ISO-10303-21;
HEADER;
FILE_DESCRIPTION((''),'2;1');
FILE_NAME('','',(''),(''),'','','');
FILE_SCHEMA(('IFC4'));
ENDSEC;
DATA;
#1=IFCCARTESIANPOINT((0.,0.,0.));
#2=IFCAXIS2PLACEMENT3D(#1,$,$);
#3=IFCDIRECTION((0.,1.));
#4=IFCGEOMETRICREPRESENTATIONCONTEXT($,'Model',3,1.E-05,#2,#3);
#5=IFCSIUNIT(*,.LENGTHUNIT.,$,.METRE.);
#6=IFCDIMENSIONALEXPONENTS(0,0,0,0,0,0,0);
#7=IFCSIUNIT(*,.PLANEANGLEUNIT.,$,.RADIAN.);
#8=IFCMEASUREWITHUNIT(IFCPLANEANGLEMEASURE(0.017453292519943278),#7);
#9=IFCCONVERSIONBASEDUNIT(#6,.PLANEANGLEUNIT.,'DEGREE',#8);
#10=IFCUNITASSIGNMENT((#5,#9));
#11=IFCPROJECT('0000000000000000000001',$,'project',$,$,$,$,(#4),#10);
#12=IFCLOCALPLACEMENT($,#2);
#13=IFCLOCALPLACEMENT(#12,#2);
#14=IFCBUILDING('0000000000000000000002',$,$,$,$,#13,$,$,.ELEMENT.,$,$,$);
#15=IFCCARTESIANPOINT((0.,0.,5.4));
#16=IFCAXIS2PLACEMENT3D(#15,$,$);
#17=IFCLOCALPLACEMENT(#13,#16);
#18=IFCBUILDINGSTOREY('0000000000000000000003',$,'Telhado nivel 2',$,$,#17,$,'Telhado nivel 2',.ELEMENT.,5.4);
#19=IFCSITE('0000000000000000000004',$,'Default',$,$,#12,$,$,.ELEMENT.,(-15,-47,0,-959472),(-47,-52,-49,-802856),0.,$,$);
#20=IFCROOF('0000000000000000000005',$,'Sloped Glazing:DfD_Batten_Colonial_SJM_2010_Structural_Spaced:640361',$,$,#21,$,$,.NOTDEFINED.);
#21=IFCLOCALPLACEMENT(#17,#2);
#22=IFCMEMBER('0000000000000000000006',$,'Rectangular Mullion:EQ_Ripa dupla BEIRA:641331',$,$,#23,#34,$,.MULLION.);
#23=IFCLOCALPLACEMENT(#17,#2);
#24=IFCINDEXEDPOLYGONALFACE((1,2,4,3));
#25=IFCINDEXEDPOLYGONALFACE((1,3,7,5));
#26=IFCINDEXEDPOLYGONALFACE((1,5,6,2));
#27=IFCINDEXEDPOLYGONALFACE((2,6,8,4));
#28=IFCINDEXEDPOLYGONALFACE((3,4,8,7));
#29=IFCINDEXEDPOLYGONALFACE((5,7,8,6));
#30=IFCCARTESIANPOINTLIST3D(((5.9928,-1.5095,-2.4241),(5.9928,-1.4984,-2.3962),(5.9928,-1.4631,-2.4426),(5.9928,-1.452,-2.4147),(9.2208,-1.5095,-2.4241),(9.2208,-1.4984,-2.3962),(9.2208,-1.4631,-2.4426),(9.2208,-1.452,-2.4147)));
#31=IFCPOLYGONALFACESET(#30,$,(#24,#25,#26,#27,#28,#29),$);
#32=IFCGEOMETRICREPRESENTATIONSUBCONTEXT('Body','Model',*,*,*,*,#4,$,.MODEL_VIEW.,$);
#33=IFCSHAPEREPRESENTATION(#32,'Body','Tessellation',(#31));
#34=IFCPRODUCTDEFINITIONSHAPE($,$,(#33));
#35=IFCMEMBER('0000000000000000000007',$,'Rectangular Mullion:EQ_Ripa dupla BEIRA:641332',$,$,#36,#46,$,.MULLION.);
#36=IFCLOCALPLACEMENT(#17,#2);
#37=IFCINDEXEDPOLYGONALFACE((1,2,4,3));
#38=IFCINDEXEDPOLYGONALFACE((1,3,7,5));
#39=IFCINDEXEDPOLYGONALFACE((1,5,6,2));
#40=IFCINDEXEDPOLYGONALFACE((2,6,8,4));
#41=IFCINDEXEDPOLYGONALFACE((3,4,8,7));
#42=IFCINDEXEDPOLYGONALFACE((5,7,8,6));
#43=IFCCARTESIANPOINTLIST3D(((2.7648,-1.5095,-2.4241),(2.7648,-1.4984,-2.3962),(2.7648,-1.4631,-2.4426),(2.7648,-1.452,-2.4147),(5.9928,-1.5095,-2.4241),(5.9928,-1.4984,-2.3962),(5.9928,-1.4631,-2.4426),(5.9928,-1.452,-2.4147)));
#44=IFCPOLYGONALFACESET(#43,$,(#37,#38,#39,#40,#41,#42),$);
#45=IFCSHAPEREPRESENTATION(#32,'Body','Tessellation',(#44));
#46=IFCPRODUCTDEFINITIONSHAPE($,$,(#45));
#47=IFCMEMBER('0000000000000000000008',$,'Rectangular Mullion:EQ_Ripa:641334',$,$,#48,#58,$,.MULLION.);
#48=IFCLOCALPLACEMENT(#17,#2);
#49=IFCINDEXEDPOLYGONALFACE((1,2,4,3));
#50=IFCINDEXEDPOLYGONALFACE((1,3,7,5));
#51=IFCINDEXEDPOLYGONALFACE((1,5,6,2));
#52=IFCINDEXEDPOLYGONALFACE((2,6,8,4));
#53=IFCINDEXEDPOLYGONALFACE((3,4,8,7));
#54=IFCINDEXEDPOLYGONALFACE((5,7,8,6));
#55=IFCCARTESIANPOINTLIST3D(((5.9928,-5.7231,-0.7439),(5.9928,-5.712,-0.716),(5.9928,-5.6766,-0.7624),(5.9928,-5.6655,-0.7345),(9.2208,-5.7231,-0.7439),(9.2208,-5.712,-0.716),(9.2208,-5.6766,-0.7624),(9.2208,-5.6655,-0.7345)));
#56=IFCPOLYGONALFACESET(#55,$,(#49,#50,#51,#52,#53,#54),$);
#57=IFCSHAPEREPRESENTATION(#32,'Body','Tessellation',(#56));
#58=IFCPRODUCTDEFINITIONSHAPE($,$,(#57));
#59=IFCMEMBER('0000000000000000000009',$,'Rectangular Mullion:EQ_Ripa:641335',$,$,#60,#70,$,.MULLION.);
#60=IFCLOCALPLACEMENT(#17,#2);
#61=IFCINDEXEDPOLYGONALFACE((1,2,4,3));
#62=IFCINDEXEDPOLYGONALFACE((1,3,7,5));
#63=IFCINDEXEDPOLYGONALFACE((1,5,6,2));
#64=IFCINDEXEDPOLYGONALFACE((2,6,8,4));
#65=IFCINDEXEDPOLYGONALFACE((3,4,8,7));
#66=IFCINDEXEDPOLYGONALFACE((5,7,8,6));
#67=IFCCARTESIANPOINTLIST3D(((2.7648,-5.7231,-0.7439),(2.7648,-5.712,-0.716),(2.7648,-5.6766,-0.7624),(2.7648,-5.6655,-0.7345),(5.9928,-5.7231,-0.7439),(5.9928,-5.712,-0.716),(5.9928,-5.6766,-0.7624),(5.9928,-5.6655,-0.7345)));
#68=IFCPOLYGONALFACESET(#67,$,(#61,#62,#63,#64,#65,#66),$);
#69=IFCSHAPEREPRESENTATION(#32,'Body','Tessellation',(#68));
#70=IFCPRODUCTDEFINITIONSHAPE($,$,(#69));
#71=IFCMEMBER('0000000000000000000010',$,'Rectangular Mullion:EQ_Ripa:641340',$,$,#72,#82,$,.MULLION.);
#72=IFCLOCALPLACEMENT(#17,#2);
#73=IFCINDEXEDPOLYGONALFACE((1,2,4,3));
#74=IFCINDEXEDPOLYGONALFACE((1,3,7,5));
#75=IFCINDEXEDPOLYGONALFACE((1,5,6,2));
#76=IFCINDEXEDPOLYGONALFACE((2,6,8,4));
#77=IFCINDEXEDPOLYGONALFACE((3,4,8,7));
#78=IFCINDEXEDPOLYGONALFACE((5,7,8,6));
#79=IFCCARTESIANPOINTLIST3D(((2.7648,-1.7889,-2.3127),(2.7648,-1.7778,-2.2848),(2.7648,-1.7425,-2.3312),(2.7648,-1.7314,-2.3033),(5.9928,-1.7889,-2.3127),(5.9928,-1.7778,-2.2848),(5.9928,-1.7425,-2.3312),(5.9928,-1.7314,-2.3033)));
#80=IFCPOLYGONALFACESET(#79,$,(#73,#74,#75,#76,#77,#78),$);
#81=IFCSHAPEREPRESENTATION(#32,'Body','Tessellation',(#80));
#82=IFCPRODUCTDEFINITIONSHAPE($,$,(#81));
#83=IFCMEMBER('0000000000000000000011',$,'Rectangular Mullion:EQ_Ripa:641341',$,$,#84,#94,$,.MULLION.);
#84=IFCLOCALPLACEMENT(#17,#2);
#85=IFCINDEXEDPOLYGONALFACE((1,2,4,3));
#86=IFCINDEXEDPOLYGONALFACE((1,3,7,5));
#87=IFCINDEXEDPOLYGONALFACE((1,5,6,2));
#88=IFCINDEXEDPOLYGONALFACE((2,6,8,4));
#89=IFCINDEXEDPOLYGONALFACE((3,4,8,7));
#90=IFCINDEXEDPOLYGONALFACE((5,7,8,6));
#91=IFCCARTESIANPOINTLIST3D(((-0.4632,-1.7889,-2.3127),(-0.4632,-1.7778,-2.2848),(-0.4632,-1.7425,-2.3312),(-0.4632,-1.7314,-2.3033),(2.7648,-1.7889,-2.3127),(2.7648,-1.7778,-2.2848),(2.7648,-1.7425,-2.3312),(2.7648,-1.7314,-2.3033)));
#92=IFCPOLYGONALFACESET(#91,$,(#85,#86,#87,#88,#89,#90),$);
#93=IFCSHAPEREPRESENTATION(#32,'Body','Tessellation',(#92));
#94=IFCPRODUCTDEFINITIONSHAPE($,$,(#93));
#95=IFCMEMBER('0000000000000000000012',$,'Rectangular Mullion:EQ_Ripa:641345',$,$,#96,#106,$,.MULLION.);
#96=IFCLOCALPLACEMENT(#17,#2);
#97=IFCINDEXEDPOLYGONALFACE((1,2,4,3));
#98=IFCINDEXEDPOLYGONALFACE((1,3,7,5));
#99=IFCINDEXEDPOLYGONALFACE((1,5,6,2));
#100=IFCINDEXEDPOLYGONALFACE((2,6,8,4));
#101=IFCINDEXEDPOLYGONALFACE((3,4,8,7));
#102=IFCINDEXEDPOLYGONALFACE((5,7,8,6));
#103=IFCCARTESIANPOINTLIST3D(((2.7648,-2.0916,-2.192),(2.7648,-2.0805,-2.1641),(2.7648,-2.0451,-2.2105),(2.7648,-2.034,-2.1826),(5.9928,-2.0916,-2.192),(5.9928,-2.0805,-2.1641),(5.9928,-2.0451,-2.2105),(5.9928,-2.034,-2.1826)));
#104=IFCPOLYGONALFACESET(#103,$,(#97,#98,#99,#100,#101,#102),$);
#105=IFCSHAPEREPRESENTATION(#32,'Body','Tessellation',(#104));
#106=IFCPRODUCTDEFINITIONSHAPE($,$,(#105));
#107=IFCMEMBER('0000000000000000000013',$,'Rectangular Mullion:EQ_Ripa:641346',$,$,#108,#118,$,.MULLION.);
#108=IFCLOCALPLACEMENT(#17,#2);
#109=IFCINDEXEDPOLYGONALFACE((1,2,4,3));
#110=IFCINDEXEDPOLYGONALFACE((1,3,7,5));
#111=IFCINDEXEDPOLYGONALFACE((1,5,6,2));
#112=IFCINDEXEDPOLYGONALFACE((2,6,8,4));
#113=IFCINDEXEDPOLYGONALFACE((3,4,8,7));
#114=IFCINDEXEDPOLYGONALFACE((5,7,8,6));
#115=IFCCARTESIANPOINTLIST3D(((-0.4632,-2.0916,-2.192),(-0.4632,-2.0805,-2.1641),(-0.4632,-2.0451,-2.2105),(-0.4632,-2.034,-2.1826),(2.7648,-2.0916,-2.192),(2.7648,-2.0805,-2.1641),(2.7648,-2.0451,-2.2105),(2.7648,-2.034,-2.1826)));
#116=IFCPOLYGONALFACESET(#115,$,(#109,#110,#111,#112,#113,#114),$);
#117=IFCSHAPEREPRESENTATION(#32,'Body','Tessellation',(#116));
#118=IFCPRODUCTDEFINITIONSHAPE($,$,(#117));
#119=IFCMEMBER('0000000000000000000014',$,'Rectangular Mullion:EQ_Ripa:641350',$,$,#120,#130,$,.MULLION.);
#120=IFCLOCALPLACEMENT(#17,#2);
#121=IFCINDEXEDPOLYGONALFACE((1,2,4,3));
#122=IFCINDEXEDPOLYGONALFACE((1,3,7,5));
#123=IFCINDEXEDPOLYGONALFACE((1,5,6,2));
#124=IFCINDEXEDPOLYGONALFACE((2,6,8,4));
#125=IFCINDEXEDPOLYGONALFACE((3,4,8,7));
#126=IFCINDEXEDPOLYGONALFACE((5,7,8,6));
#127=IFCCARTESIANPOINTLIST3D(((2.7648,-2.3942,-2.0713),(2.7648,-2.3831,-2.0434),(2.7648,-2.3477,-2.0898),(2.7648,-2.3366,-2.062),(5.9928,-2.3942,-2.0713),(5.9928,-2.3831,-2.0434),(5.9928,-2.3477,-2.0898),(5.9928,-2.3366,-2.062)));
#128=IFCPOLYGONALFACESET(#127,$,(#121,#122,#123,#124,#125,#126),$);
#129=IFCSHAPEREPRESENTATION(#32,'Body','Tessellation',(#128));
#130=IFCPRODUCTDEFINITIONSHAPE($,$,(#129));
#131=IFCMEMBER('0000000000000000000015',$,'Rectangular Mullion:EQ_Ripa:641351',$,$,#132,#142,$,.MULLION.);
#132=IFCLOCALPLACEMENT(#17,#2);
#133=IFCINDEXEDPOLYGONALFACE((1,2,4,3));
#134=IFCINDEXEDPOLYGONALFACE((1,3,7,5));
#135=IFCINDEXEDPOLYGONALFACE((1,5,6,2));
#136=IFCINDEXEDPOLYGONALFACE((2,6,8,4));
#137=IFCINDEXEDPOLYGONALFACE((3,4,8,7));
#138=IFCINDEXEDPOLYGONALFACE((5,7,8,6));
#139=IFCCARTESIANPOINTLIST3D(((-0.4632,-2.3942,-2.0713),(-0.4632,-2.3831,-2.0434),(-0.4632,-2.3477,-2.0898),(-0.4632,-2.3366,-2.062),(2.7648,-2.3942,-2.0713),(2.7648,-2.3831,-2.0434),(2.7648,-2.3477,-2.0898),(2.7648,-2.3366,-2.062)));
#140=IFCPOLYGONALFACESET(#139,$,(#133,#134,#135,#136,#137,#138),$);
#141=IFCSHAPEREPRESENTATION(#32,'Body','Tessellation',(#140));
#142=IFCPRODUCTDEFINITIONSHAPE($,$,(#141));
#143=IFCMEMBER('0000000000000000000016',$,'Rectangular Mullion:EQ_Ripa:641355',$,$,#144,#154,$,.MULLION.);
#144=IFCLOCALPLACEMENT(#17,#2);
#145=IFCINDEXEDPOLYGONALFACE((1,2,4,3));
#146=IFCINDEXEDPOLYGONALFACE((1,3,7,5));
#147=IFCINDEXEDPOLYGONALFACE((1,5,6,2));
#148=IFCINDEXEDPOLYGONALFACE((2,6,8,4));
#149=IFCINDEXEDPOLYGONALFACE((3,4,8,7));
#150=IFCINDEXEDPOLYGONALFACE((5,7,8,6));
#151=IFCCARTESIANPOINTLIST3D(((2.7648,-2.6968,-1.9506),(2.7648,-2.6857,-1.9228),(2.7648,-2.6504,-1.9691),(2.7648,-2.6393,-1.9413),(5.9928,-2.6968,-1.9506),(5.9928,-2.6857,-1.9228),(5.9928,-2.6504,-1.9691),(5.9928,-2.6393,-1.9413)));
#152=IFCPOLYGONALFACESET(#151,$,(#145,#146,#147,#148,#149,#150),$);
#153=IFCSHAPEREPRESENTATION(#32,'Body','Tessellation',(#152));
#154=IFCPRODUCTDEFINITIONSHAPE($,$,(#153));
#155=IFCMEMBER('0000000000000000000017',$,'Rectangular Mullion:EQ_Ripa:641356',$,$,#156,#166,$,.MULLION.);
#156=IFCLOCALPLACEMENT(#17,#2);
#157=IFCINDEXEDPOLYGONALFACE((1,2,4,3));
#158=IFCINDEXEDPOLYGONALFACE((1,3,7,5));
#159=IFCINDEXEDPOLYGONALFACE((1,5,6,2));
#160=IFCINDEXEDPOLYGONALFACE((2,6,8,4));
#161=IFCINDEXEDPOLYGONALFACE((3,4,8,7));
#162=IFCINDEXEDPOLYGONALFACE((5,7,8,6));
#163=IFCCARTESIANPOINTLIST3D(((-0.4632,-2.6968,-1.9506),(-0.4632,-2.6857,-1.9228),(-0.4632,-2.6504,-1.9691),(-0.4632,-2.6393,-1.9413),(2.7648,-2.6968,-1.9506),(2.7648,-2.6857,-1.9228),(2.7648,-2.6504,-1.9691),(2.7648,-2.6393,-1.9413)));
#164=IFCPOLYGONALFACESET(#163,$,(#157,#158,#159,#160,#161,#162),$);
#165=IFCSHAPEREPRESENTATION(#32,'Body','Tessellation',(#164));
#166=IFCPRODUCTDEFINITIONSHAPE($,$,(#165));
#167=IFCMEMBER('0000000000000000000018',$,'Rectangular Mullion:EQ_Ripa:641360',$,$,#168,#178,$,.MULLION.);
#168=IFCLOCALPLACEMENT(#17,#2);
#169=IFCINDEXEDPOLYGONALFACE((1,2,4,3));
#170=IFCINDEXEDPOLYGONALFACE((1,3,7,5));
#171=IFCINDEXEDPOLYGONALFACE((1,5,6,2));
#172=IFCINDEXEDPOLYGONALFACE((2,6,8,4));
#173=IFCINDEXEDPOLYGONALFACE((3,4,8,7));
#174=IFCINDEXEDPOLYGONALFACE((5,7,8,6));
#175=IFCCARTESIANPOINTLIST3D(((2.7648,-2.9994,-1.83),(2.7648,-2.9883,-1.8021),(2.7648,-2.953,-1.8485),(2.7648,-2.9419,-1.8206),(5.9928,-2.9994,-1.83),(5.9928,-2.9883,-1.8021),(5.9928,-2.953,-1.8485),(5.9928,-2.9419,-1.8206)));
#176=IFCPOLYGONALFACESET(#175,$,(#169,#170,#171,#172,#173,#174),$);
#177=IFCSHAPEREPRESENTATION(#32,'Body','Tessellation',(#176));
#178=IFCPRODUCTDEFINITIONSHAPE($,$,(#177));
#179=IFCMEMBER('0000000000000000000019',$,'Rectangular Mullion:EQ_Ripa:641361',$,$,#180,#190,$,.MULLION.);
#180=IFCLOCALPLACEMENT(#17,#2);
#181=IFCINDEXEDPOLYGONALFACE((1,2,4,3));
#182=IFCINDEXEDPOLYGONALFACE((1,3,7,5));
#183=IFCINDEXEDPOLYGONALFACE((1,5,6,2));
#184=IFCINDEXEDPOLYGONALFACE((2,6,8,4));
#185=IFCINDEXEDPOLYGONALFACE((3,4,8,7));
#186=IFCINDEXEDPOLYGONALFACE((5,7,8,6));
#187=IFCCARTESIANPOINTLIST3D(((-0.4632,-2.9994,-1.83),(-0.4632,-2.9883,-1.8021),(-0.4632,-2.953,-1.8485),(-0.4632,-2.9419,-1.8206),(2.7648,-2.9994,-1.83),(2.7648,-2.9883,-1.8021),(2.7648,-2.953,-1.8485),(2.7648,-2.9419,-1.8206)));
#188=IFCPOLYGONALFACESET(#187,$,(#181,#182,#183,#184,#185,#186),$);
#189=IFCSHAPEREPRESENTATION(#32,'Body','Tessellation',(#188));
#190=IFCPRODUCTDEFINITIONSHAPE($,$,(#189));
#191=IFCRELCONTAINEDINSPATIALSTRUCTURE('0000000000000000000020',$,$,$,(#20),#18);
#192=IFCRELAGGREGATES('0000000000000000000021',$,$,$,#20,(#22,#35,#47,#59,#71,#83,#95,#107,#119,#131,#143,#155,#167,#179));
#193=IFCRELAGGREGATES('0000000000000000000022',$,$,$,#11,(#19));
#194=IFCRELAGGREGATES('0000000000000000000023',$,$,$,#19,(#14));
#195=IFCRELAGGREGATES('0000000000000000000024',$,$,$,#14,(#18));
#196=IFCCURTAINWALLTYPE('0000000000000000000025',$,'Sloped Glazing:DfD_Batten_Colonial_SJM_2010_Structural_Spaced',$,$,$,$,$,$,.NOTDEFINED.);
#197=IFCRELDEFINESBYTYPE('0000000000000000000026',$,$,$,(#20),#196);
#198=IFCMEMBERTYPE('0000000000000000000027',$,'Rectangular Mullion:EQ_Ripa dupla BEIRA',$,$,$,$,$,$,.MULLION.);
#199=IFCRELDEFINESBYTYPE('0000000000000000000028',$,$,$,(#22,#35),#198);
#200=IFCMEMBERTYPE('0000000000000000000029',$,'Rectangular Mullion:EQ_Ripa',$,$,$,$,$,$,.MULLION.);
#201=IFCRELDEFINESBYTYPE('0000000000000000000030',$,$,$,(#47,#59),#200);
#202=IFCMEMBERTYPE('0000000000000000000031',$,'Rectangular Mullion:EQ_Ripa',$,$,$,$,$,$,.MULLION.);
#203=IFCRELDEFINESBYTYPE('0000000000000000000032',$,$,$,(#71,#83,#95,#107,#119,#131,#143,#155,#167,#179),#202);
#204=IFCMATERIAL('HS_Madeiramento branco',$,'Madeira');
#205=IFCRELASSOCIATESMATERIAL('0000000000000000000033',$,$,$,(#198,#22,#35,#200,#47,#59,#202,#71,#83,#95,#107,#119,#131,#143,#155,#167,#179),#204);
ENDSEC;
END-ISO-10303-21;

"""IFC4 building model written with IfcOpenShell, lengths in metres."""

from ifc_helpers import new_model, entity, si_unit, converted_unit, direction, frame, origin, place, context, subcontext, project, spatial, indexed_curve, outline, extrude, source, transform, mapped, material, type_object, type_shapes, element, aggregate, save


model = new_model("IFC4")

# Units and contexts
model_context = context("Model", 3, precision=1e-05, world=origin(), true_north=direction((0.0, 1.0)))
body_context = subcontext(model_context, "Body", "Model", "MODEL_VIEW")
ifc_project = project(units=[si_unit("LENGTHUNIT", "METRE"), converted_unit("PLANEANGLEUNIT", "DEGREE", entity("IfcPlaneAngleMeasure", 0.017453292519943278), si_unit("PLANEANGLEUNIT", "RADIAN"), dimensions=[0, 0, 0, 0, 0, 0, 0])], contexts=[model_context])

# Site, building, storey
site_placement = place(None, origin())
site = spatial("IfcSite", under=ifc_project, at=site_placement, Name="Default", CompositionType="ELEMENT", RefLatitude=(-15, -47, 0, -959472), RefLongitude=(-47, -52, -49, -802856), RefElevation=0.0)
building_placement = place(site_placement, origin())
building = spatial("IfcBuilding", under=site, at=building_placement, CompositionType="ELEMENT")
storey_placement = place(building_placement, frame((0.0, 0.0, 5.4)))
storey = spatial("IfcBuildingStorey", under=building, at=storey_placement, Name="Telhado nivel 2", LongName="Telhado nivel 2", CompositionType="ELEMENT", Elevation=5.4)

# Roof, members
curtain_wall_type = type_object("IfcCurtainWallType", Name="Sloped Glazing:DfD_Batten_Colonial_SJM_2010_Structural_Spaced", PredefinedType="NOTDEFINED")
roof_placement = place(storey_placement, frame((0.0, 0.0, -5.4)))
roof = element("IfcRoof", 1, at=roof_placement, inside=storey, type_object=curtain_wall_type, Name="Sloped Glazing:DfD_Batten_Colonial_SJM_2010_Structural_Spaced:640361", PredefinedType="NOTDEFINED")
ifc_material = material(Name="HS_Madeiramento branco", Category="Madeira")
member_type_1 = type_object("IfcMemberType", Name="Rectangular Mullion:EQ_Ripa dupla BEIRA", PredefinedType="MULLION", material=ifc_material)
shared_shape_1 = source(origin(), body_context, "Body", "SweptSolid", [
    extrude(outline(indexed_curve([(-0.025, -0.015), (0.025, -0.015), (0.025, 0.015), (-0.025, 0.015), (-0.025, -0.015)], self_intersect=False)), frame((-0.025, 0.0, -3.228), z_axis=(0.0, 0.0, 1.0), x_axis=(-1.0, 0.0, 0.0)), (0.0, 0.0, 1.0), 3.228),
])
type_shapes(member_type_1, [shared_shape_1])
member_1_placement = place(roof_placement, frame((5.9928, -1.4575, 2.9713), z_axis=(-1.0, 0.0, 0.0), x_axis=(0.0, 0.928874, -0.370395)))
member_1 = element("IfcMember", 2, at=member_1_placement, type_object=member_type_1, material=ifc_material, Name="Rectangular Mullion:EQ_Ripa dupla BEIRA:641331", PredefinedType="MULLION", context=body_context, shape_type="MappedRepresentation", body=[
    mapped(shared_shape_1, transform((0.0, 0.0, 0.0), scale=1.0)),
])
member_2_placement = place(roof_placement, frame((2.7648, -1.4575, 2.9713), z_axis=(-1.0, 0.0, 0.0), x_axis=(0.0, 0.928874, -0.370395)))
member_2 = element("IfcMember", 3, at=member_2_placement, type_object=member_type_1, material=ifc_material, Name="Rectangular Mullion:EQ_Ripa dupla BEIRA:641332", PredefinedType="MULLION", context=body_context, shape_type="MappedRepresentation", body=[
    mapped(shared_shape_1, transform((0.0, 0.0, 0.0), scale=1.0)),
])
member_type_2 = type_object("IfcMemberType", Name="Rectangular Mullion:EQ_Ripa", PredefinedType="MULLION", material=ifc_material)
shared_shape_2 = source(origin(), body_context, "Body", "SweptSolid", [
    extrude(outline(indexed_curve([(-0.025, -0.015), (0.025, -0.015), (0.025, 0.015), (-0.025, 0.015), (-0.025, -0.015)], self_intersect=False)), frame((-0.025, 0.0, -3.228), z_axis=(0.0, 0.0, 1.0), x_axis=(-1.0, 0.0, 0.0)), (0.0, 0.0, 1.0), 3.228),
])
type_shapes(member_type_2, [shared_shape_2])
member_3_placement = place(roof_placement, frame((9.2208, -5.7175, 4.6701), z_axis=(1.0, 0.0, 0.0), x_axis=(0.0, -0.928874, 0.370395)))
member_3 = element("IfcMember", 4, at=member_3_placement, type_object=member_type_2, material=ifc_material, Name="Rectangular Mullion:EQ_Ripa:641334", PredefinedType="MULLION", context=body_context, shape_type="MappedRepresentation", body=[
    mapped(shared_shape_2, transform((0.0, 0.0, 0.0), scale=1.0)),
])
member_4_placement = place(roof_placement, frame((5.9928, -5.7175, 4.6701), z_axis=(1.0, 0.0, 0.0), x_axis=(0.0, -0.928874, 0.370395)))
member_4 = element("IfcMember", 5, at=member_4_placement, type_object=member_type_2, material=ifc_material, Name="Rectangular Mullion:EQ_Ripa:641335", PredefinedType="MULLION", context=body_context, shape_type="MappedRepresentation", body=[
    mapped(shared_shape_2, transform((0.0, 0.0, 0.0), scale=1.0)),
])
member_type_3 = type_object("IfcMemberType", Name="Rectangular Mullion:EQ_Ripa", PredefinedType="MULLION", material=ifc_material)
shared_shape_3 = source(origin(), body_context, "Body", "SweptSolid", [
    extrude(outline(indexed_curve([(-0.025, -0.015), (0.025, -0.015), (0.025, 0.015), (-0.025, 0.015), (-0.025, -0.015)], self_intersect=False)), frame((0.0, 0.0, -3.228), z_axis=(0.0, 0.0, 1.0), x_axis=(-1.0, 0.0, 0.0)), (0.0, 0.0, 1.0), 3.228),
])
type_shapes(member_type_3, [shared_shape_3])
member_5_placement = place(roof_placement, frame((5.9928, -1.7602, 3.092), z_axis=(1.0, 0.0, 0.0), x_axis=(0.0, -0.928874, 0.370395)))
member_5 = element("IfcMember", 6, at=member_5_placement, type_object=member_type_3, material=ifc_material, Name="Rectangular Mullion:EQ_Ripa:641340", PredefinedType="MULLION", context=body_context, shape_type="MappedRepresentation", body=[
    mapped(shared_shape_3, transform((0.0, 0.0, 0.0), scale=1.0)),
])
member_6_placement = place(roof_placement, frame((2.7648, -1.7602, 3.092), z_axis=(1.0, 0.0, 0.0), x_axis=(0.0, -0.928874, 0.370395)))
member_6 = element("IfcMember", 7, at=member_6_placement, type_object=member_type_3, material=ifc_material, Name="Rectangular Mullion:EQ_Ripa:641341", PredefinedType="MULLION", context=body_context, shape_type="MappedRepresentation", body=[
    mapped(shared_shape_3, transform((0.0, 0.0, 0.0), scale=1.0)),
])
member_7_placement = place(roof_placement, frame((5.9928, -2.0628, 3.2127), z_axis=(1.0, 0.0, 0.0), x_axis=(0.0, -0.928874, 0.370395)))
member_7 = element("IfcMember", 8, at=member_7_placement, type_object=member_type_3, material=ifc_material, Name="Rectangular Mullion:EQ_Ripa:641345", PredefinedType="MULLION", context=body_context, shape_type="MappedRepresentation", body=[
    mapped(shared_shape_3, transform((0.0, 0.0, 0.0), scale=1.0)),
])
member_8_placement = place(roof_placement, frame((2.7648, -2.0628, 3.2127), z_axis=(1.0, 0.0, 0.0), x_axis=(0.0, -0.928874, 0.370395)))
member_8 = element("IfcMember", 9, at=member_8_placement, type_object=member_type_3, material=ifc_material, Name="Rectangular Mullion:EQ_Ripa:641346", PredefinedType="MULLION", context=body_context, shape_type="MappedRepresentation", body=[
    mapped(shared_shape_3, transform((0.0, 0.0, 0.0), scale=1.0)),
])
member_9_placement = place(roof_placement, frame((5.9928, -2.3654, 3.3334), z_axis=(1.0, 0.0, 0.0), x_axis=(0.0, -0.928874, 0.370395)))
member_9 = element("IfcMember", 10, at=member_9_placement, type_object=member_type_3, material=ifc_material, Name="Rectangular Mullion:EQ_Ripa:641350", PredefinedType="MULLION", context=body_context, shape_type="MappedRepresentation", body=[
    mapped(shared_shape_3, transform((0.0, 0.0, 0.0), scale=1.0)),
])
member_10_placement = place(roof_placement, frame((2.7648, -2.3654, 3.3334), z_axis=(1.0, 0.0, 0.0), x_axis=(0.0, -0.928874, 0.370395)))
member_10 = element("IfcMember", 11, at=member_10_placement, type_object=member_type_3, material=ifc_material, Name="Rectangular Mullion:EQ_Ripa:641351", PredefinedType="MULLION", context=body_context, shape_type="MappedRepresentation", body=[
    mapped(shared_shape_3, transform((0.0, 0.0, 0.0), scale=1.0)),
])
member_11_placement = place(roof_placement, frame((5.9928, -2.668, 3.454), z_axis=(1.0, 0.0, 0.0), x_axis=(0.0, -0.928874, 0.370395)))
member_11 = element("IfcMember", 12, at=member_11_placement, type_object=member_type_3, material=ifc_material, Name="Rectangular Mullion:EQ_Ripa:641355", PredefinedType="MULLION", context=body_context, shape_type="MappedRepresentation", body=[
    mapped(shared_shape_3, transform((0.0, 0.0, 0.0), scale=1.0)),
])
member_12_placement = place(roof_placement, frame((2.7648, -2.668, 3.454), z_axis=(1.0, 0.0, 0.0), x_axis=(0.0, -0.928874, 0.370395)))
member_12 = element("IfcMember", 13, at=member_12_placement, type_object=member_type_3, material=ifc_material, Name="Rectangular Mullion:EQ_Ripa:641356", PredefinedType="MULLION", context=body_context, shape_type="MappedRepresentation", body=[
    mapped(shared_shape_3, transform((0.0, 0.0, 0.0), scale=1.0)),
])
member_13_placement = place(roof_placement, frame((5.9928, -2.9707, 3.5747), z_axis=(1.0, 0.0, 0.0), x_axis=(0.0, -0.928874, 0.370395)))
member_13 = element("IfcMember", 14, at=member_13_placement, type_object=member_type_3, material=ifc_material, Name="Rectangular Mullion:EQ_Ripa:641360", PredefinedType="MULLION", context=body_context, shape_type="MappedRepresentation", body=[
    mapped(shared_shape_3, transform((0.0, 0.0, 0.0), scale=1.0)),
])
member_14_placement = place(roof_placement, frame((2.7648, -2.9707, 3.5747), z_axis=(1.0, 0.0, 0.0), x_axis=(0.0, -0.928874, 0.370395)))
member_14 = element("IfcMember", 15, at=member_14_placement, type_object=member_type_3, material=ifc_material, Name="Rectangular Mullion:EQ_Ripa:641361", PredefinedType="MULLION", context=body_context, shape_type="MappedRepresentation", body=[
    mapped(shared_shape_3, transform((0.0, 0.0, 0.0), scale=1.0)),
])
aggregate(roof, [member_1, member_2, member_3, member_4, member_5, member_6, member_7, member_8, member_9, member_10, member_11, member_12, member_13, member_14])

save(model, "model.ifc")
